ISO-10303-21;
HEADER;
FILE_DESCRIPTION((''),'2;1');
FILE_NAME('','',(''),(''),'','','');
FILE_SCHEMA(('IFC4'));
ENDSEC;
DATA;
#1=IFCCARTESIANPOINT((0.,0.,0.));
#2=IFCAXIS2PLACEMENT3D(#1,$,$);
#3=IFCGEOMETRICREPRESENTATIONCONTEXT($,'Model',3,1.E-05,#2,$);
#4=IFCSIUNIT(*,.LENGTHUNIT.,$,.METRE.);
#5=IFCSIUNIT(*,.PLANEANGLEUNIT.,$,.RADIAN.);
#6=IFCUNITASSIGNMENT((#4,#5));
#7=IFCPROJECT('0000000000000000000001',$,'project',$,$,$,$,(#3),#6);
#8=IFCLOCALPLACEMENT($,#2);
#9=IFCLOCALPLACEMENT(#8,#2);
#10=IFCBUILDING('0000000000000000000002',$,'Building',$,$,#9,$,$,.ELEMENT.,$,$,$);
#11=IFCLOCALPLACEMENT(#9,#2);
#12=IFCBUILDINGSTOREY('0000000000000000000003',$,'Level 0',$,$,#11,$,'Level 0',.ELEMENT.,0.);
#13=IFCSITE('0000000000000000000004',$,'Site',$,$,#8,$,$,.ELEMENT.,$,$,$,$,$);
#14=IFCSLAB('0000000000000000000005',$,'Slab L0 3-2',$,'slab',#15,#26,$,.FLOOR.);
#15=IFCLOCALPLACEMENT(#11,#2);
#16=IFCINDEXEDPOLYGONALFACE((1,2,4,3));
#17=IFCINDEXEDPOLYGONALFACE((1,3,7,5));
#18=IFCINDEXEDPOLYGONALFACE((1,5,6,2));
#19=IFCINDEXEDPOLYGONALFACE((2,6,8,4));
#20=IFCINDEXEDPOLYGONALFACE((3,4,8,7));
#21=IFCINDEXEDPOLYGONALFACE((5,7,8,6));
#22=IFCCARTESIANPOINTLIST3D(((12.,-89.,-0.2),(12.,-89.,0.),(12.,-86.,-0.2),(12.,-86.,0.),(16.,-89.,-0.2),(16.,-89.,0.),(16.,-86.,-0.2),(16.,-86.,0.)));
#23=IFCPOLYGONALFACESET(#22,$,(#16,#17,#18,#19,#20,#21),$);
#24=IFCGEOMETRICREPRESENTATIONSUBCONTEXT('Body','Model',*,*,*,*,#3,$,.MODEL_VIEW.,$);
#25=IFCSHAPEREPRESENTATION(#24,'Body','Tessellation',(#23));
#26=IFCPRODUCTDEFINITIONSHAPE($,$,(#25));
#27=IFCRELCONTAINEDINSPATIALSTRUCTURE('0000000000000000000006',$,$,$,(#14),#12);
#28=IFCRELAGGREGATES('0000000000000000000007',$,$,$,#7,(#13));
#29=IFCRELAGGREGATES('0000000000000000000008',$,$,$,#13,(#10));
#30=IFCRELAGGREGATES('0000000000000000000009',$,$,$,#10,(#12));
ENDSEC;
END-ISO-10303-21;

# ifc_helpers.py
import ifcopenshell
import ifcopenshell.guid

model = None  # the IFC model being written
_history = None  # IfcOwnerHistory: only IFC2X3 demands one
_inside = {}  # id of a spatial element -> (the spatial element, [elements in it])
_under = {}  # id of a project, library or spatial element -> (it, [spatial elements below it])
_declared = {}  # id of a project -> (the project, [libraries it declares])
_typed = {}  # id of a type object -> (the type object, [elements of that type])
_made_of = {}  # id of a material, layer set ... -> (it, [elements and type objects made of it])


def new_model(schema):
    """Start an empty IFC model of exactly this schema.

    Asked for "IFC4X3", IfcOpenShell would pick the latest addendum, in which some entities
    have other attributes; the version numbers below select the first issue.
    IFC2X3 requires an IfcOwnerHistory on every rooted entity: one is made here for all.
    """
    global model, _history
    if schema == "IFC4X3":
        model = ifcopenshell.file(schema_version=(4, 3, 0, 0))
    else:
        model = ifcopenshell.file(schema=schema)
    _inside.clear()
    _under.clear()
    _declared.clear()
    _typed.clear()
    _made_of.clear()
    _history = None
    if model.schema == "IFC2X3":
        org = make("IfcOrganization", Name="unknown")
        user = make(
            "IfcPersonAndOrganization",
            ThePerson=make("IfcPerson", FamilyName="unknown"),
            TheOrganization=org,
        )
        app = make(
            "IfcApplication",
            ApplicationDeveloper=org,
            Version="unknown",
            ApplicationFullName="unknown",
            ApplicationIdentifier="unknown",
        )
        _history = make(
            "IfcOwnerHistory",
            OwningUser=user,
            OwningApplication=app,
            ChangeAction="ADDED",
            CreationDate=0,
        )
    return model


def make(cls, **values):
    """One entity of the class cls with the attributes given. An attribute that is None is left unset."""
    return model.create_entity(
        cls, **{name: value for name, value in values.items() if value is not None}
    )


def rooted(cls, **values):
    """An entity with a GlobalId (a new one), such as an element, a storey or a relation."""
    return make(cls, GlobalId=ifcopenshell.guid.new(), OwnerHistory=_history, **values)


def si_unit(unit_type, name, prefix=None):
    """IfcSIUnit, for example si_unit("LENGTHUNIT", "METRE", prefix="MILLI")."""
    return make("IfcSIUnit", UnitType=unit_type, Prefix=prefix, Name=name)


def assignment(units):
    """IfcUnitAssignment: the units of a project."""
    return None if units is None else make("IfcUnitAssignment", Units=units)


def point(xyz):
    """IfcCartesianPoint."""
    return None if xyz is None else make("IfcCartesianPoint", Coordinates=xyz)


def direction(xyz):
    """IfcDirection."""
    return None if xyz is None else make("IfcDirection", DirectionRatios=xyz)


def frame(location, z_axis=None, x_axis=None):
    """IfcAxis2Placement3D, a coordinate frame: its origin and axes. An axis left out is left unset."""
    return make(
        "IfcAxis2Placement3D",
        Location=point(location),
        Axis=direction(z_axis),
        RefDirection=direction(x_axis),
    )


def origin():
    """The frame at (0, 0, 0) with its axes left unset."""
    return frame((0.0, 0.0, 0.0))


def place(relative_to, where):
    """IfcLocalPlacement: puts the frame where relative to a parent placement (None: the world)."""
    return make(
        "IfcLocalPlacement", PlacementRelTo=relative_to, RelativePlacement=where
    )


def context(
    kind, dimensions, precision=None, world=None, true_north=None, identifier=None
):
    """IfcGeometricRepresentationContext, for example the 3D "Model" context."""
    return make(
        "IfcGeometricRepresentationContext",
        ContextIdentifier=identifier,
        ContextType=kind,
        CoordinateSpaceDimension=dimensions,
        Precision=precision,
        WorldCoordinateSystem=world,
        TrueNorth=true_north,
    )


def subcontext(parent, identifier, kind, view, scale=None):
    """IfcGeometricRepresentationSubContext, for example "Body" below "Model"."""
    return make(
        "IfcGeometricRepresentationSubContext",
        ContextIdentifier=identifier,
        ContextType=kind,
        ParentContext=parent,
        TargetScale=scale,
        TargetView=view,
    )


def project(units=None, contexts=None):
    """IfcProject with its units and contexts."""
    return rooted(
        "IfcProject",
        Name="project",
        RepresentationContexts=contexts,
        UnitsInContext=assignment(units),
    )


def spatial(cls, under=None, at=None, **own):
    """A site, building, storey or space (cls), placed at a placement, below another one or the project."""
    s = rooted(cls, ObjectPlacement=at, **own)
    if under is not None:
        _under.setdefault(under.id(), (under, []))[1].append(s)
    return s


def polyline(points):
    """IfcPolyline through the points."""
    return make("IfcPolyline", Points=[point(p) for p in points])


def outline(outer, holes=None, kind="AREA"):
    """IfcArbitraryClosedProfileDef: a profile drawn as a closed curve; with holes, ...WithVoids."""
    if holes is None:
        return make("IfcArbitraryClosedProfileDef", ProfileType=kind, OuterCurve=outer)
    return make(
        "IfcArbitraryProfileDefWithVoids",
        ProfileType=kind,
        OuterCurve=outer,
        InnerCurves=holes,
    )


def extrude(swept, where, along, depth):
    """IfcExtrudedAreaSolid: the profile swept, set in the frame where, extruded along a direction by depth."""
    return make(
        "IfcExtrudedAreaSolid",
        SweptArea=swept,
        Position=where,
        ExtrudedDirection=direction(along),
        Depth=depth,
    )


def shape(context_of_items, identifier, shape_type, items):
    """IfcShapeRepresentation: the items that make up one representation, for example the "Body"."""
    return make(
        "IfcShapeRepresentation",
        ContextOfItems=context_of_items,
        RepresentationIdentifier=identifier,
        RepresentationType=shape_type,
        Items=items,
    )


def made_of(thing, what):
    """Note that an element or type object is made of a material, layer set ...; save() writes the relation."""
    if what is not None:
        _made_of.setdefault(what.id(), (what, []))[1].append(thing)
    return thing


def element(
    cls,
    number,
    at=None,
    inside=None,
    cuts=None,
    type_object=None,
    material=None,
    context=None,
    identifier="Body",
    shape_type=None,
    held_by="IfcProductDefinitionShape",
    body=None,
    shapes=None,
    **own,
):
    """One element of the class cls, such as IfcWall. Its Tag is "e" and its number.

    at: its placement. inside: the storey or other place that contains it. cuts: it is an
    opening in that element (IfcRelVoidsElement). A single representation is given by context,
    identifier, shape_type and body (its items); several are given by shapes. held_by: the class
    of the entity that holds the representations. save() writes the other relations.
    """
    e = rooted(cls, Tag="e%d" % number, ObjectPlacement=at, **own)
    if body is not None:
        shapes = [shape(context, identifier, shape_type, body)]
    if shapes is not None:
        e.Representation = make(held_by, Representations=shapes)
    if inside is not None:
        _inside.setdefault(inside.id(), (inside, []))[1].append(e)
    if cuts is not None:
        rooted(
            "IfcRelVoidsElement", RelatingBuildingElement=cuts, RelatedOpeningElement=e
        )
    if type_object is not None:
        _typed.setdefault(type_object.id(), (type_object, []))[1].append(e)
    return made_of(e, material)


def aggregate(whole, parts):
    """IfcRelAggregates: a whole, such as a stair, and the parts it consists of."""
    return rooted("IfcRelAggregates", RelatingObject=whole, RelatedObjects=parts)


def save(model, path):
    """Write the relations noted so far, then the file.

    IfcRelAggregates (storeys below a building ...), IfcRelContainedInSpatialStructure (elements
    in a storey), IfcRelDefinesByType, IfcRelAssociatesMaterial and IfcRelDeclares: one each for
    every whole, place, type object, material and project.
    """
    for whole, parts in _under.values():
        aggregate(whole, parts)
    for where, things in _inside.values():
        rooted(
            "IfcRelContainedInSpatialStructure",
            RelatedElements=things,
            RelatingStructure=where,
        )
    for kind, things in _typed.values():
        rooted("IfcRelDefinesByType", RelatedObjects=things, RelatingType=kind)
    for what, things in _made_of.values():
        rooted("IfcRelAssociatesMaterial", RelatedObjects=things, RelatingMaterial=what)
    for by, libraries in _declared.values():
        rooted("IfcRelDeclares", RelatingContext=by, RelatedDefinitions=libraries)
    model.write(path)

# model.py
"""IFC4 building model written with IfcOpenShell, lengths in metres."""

from ifc_helpers import new_model, si_unit, frame, origin, place, context, subcontext, project, spatial, polyline, outline, extrude, element, save


model = new_model("IFC4")

# Units and contexts
model_context = context("Model", 3, precision=1e-05, world=origin())
body_context = subcontext(model_context, "Body", "Model", "MODEL_VIEW")
ifc_project = project(units=[si_unit("LENGTHUNIT", "METRE"), si_unit("PLANEANGLEUNIT", "RADIAN")], contexts=[model_context])

# Site, building, storey
site_placement = place(None, origin())
site = spatial("IfcSite", under=ifc_project, at=site_placement, Name="Site", CompositionType="ELEMENT")
building_placement = place(site_placement, origin())
building = spatial("IfcBuilding", under=site, at=building_placement, Name="Building", CompositionType="ELEMENT")
storey_placement = place(building_placement, origin())
storey = spatial("IfcBuildingStorey", under=building, at=storey_placement, Name="Level 0", LongName="Level 0", CompositionType="ELEMENT", Elevation=0.0)

# Slab
slab_1_placement = place(storey_placement, frame((0.0, 0.0, -0.2)))
element("IfcSlab", 1, at=slab_1_placement, inside=storey, Name="Slab L0 3-2", ObjectType="slab", PredefinedType="FLOOR", context=body_context, shape_type="SweptSolid", body=[
    extrude(outline(polyline([(12.0, -89.0), (16.0, -89.0), (16.0, -86.0), (12.0, -86.0), (12.0, -89.0)])), origin(), (0.0, 0.0, 1.0), 0.2),
])

save(model, "model.ifc")
